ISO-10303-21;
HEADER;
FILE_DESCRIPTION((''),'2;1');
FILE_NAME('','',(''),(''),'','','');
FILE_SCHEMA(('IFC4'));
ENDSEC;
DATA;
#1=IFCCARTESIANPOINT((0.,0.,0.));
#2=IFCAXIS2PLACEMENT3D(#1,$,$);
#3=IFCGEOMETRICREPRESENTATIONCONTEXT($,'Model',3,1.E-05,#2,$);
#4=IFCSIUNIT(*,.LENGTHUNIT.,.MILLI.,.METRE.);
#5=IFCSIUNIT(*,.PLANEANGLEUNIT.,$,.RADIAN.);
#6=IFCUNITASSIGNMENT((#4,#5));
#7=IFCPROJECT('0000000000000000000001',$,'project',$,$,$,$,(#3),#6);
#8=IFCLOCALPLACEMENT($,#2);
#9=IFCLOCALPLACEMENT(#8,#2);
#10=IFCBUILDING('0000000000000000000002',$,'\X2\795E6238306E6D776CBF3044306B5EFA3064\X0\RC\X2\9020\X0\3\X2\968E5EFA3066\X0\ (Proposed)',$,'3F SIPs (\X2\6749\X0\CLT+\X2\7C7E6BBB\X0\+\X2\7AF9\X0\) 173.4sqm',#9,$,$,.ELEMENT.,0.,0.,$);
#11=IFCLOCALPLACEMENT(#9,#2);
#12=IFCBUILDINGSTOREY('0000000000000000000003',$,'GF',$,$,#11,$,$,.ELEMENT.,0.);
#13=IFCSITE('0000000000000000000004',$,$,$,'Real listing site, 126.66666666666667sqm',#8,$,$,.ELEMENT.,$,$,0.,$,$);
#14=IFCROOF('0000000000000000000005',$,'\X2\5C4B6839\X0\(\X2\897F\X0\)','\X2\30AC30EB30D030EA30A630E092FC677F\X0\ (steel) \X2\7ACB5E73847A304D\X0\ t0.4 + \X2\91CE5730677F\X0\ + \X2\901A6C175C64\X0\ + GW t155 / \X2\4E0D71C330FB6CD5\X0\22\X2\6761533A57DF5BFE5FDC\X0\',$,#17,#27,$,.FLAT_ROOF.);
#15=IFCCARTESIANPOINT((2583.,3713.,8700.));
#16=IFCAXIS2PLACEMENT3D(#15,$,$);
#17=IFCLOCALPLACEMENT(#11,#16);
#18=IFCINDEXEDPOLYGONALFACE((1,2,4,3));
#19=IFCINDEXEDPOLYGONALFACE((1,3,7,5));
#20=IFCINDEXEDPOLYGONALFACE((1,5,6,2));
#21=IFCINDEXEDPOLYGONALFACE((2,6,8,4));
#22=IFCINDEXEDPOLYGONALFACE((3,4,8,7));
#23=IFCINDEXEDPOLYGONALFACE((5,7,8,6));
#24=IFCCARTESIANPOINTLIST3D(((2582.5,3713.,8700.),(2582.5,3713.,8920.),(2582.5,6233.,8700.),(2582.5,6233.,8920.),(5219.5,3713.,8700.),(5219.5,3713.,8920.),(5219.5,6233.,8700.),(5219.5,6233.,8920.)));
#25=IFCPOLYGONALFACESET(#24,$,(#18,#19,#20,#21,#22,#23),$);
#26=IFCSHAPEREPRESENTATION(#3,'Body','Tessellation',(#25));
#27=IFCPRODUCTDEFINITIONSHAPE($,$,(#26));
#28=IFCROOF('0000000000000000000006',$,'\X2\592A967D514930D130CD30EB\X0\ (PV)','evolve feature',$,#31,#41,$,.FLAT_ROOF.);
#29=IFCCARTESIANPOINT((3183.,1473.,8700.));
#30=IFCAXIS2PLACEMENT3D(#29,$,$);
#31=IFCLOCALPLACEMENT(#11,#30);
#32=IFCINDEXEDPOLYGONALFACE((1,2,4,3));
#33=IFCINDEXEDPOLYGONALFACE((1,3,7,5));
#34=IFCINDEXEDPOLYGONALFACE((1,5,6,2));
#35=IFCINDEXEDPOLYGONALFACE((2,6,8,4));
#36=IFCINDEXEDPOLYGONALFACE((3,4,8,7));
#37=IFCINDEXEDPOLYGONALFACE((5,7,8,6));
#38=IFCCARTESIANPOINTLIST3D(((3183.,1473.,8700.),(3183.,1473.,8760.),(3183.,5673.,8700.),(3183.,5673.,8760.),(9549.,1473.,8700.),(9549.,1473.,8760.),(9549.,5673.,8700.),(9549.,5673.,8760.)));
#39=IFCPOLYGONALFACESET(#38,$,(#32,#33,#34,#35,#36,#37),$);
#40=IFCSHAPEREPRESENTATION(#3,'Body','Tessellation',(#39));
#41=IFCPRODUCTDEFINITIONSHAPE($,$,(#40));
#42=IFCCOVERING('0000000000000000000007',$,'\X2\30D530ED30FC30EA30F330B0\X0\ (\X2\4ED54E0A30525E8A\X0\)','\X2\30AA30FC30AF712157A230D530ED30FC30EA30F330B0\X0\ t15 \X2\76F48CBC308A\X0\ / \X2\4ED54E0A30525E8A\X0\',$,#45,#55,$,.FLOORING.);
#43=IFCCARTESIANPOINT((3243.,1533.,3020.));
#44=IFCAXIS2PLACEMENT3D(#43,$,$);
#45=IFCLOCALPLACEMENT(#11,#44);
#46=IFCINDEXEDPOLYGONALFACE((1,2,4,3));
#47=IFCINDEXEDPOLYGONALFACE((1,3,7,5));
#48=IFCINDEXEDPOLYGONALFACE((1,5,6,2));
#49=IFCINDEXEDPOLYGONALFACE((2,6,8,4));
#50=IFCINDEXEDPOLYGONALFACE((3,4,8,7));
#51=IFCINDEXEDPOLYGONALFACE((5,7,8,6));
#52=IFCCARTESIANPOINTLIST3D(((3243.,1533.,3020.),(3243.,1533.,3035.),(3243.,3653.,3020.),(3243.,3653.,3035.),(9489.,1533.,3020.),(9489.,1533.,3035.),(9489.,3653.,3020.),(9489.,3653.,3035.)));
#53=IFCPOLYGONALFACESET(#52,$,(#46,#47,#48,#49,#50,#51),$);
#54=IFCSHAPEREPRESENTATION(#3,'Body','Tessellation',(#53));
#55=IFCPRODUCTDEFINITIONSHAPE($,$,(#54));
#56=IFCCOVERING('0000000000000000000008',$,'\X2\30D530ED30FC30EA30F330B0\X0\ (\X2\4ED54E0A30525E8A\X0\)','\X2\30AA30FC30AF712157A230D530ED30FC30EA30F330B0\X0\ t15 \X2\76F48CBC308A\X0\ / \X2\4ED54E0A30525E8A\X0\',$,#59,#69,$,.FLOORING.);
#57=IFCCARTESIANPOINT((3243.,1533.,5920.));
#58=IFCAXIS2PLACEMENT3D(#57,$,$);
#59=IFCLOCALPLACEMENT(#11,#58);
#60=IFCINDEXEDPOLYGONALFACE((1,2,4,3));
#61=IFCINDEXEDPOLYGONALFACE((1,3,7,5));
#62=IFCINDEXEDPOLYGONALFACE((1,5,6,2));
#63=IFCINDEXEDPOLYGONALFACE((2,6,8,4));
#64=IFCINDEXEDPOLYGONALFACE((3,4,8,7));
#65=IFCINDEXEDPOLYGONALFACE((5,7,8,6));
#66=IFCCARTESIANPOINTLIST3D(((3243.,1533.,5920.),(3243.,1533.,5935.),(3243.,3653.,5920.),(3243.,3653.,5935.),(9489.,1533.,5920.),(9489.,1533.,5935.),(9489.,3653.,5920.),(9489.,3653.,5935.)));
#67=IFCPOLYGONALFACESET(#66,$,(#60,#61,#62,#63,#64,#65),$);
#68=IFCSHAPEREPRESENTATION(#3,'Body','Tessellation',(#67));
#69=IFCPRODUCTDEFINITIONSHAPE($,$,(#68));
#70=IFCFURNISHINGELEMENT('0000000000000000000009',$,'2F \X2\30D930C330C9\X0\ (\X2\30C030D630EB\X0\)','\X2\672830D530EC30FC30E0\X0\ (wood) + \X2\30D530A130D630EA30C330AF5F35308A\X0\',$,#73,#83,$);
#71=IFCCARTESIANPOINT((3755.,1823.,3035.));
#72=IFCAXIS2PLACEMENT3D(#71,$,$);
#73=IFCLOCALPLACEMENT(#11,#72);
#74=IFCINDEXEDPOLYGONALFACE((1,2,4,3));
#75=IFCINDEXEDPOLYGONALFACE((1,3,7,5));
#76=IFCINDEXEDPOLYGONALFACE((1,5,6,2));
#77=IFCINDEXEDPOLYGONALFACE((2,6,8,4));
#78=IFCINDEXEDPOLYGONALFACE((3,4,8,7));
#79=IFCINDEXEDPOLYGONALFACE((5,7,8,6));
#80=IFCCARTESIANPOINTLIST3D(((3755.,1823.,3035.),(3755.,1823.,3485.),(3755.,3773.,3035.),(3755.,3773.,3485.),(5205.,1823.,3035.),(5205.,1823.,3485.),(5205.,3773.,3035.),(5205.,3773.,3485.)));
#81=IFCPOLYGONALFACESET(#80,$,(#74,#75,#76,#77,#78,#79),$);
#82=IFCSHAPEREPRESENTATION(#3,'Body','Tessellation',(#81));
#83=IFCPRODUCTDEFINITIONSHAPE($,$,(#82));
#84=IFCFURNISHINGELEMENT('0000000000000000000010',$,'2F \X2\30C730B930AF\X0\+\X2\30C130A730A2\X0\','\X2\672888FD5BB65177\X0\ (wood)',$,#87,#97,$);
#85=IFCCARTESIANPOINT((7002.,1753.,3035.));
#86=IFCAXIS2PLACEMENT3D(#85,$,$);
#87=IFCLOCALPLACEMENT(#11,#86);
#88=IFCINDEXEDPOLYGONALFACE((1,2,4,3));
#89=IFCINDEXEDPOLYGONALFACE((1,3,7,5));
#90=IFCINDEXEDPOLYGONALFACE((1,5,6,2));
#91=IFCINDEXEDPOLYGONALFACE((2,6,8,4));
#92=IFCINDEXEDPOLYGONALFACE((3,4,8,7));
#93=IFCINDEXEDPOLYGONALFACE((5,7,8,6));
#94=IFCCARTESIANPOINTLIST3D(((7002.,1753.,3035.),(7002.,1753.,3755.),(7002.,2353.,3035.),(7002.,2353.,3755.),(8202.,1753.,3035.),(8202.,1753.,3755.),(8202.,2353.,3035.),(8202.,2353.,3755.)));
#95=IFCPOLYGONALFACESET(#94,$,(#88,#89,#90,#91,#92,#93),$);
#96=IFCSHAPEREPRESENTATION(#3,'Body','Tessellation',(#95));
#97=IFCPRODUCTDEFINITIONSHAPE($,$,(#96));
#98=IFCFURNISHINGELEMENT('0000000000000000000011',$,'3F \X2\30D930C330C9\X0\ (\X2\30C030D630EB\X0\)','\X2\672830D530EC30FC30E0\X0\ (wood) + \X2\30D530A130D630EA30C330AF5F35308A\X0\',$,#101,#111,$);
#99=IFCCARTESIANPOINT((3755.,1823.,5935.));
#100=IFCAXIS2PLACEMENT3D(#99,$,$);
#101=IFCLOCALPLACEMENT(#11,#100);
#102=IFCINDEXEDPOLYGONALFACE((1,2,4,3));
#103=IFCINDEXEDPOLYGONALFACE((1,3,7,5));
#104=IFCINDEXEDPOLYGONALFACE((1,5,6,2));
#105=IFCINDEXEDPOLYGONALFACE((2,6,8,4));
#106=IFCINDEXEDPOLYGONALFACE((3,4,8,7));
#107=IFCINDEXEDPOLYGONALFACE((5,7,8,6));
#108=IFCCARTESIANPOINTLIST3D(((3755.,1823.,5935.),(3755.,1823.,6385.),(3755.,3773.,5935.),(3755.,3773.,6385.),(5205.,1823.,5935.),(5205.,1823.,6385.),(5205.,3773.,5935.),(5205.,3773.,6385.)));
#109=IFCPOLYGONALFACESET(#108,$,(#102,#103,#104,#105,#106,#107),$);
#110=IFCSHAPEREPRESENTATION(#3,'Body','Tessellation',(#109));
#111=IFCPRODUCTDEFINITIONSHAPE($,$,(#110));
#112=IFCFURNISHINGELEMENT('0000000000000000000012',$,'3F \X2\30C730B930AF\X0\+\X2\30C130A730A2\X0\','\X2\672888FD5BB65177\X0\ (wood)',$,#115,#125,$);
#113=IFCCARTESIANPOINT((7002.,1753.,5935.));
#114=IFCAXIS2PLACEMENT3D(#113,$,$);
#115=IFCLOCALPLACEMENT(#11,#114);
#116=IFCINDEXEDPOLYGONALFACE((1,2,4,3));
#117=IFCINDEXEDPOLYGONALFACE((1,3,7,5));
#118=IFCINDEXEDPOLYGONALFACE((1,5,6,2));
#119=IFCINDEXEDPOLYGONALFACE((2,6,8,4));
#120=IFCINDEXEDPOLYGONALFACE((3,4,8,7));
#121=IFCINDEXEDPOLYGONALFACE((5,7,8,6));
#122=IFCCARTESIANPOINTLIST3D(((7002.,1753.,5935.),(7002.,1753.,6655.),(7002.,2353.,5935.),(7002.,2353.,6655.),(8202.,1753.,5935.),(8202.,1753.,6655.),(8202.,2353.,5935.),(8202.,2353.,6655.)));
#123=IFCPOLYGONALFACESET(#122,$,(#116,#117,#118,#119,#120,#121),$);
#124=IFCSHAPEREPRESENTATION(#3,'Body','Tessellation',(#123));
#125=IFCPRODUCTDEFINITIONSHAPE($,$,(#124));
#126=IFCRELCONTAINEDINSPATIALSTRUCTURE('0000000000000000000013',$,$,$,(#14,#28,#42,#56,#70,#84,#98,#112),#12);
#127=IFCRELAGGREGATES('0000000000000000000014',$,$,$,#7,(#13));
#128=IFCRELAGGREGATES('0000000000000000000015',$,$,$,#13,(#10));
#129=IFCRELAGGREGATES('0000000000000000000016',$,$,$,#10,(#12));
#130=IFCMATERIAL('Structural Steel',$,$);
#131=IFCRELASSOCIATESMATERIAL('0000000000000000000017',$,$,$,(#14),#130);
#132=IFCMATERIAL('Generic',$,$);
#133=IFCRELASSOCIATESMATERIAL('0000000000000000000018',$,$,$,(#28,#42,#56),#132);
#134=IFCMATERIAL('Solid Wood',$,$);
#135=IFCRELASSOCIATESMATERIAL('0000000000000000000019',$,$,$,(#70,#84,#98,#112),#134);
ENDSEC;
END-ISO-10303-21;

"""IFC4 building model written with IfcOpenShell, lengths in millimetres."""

from ifc_helpers import new_model, si_unit, frame, frame_2d, origin, place, context, project, spatial, rectangle, extrude, material, element, save


model = new_model("IFC4")

# Units and contexts
model_context = context("Model", 3, precision=1e-05, world=origin())
ifc_project = project(units=[si_unit("LENGTHUNIT", "METRE", prefix="MILLI"), si_unit("PLANEANGLEUNIT", "RADIAN")], contexts=[model_context])

# Site, building, storey
site_placement = place(None, origin())
site = spatial("IfcSite", under=ifc_project, at=site_placement, ObjectType="Real listing site, 126.66666666666667sqm", CompositionType="ELEMENT", RefElevation=0.0)
building_placement = place(site_placement, origin())
building = spatial("IfcBuilding", under=site, at=building_placement, Name="神戸の海沿いに建つRC造3階建て (Proposed)", ObjectType="3F SIPs (杉CLT+籾殻+竹) 173.4sqm", CompositionType="ELEMENT", ElevationOfRefHeight=0.0, ElevationOfTerrain=0.0)
storey_placement = place(building_placement, origin())
storey = spatial("IfcBuildingStorey", under=building, at=storey_placement, Name="GF", CompositionType="ELEMENT", Elevation=0.0)

# Shared definitions
ifc_material_1 = material(Name="Solid Wood")

# Roofs
ifc_material_2 = material(Name="Structural Steel")
roof_1_placement = place(storey_placement, frame((2583.0, 3713.0, 8700.0)))
element("IfcRoof", 1, at=roof_1_placement, inside=storey, material=ifc_material_2, Name="屋根(西)", Description="ガルバリウム鋼板 (steel) 立平葺き t0.4 + 野地板 + 通気層 + GW t155 / 不燃・法22条区域対応", PredefinedType="FLAT_ROOF", context=model_context, shape_type="SweptSolid", body=[
    extrude(rectangle(XDim=2637.0, YDim=2520.0, at=frame_2d((1318.0, 1260.0))), frame((2583.0, 3713.0, 8700.0)), (0.0, 0.0, 1.0), 220.0),
])
ifc_material_3 = material(Name="Generic")
roof_2_placement = place(storey_placement, frame((3183.0, 1473.0, 8700.0)))
element("IfcRoof", 2, at=roof_2_placement, inside=storey, material=ifc_material_3, Name="太陽光パネル (PV)", Description="evolve feature", PredefinedType="FLAT_ROOF", context=model_context, shape_type="SweptSolid", body=[
    extrude(rectangle(XDim=6366.0, YDim=4200.0, at=frame_2d((3183.0, 2100.0))), frame((3183.0, 1473.0, 8700.0)), (0.0, 0.0, 1.0), 60.0),
])

# Coverings
covering_1_placement = place(storey_placement, frame((3243.0, 1533.0, 3020.0)))
element("IfcCovering", 3, at=covering_1_placement, inside=storey, material=ifc_material_3, Name="フローリング (仕上げ床)", Description="オーク無垢フローリング t15 直貼り / 仕上げ床", PredefinedType="FLOORING", context=model_context, shape_type="SweptSolid", body=[
    extrude(rectangle(XDim=6246.0, YDim=2120.0, at=frame_2d((3123.0, 1060.0))), frame((3243.0, 1533.0, 3020.0)), (0.0, 0.0, 1.0), 15.0),
])
covering_2_placement = place(storey_placement, frame((3243.0, 1533.0, 5920.0)))
element("IfcCovering", 4, at=covering_2_placement, inside=storey, material=ifc_material_3, Name="フローリング (仕上げ床)", Description="オーク無垢フローリング t15 直貼り / 仕上げ床", PredefinedType="FLOORING", context=model_context, shape_type="SweptSolid", body=[
    extrude(rectangle(XDim=6246.0, YDim=2120.0, at=frame_2d((3123.0, 1060.0))), frame((3243.0, 1533.0, 5920.0)), (0.0, 0.0, 1.0), 15.0),
])

# Furnishing elements
furnishing_1_placement = place(storey_placement, frame((3755.0, 1823.0, 3035.0)))
element("IfcFurnishingElement", 5, at=furnishing_1_placement, inside=storey, material=ifc_material_1, Name="2F ベッド (ダブル)", Description="木フレーム (wood) + ファブリック張り", context=model_context, shape_type="SweptSolid", body=[
    extrude(rectangle(XDim=1450.0, YDim=1950.0, at=frame_2d((725.0, 975.0))), frame((3755.0, 1823.0, 3035.0)), (0.0, 0.0, 1.0), 450.0),
])
furnishing_2_placement = place(storey_placement, frame((7002.0, 1753.0, 3035.0)))
element("IfcFurnishingElement", 6, at=furnishing_2_placement, inside=storey, material=ifc_material_1, Name="2F デスク+チェア", Description="木製家具 (wood)", context=model_context, shape_type="SweptSolid", body=[
    extrude(rectangle(XDim=1200.0, YDim=600.0, at=frame_2d((600.0, 300.0))), frame((7002.0, 1753.0, 3035.0)), (0.0, 0.0, 1.0), 720.0),
])
furnishing_3_placement = place(storey_placement, frame((3755.0, 1823.0, 5935.0)))
element("IfcFurnishingElement", 7, at=furnishing_3_placement, inside=storey, material=ifc_material_1, Name="3F ベッド (ダブル)", Description="木フレーム (wood) + ファブリック張り", context=model_context, shape_type="SweptSolid", body=[
    extrude(rectangle(XDim=1450.0, YDim=1950.0, at=frame_2d((725.0, 975.0))), frame((3755.0, 1823.0, 5935.0)), (0.0, 0.0, 1.0), 450.0),
])
furnishing_4_placement = place(storey_placement, frame((7002.0, 1753.0, 5935.0)))
element("IfcFurnishingElement", 8, at=furnishing_4_placement, inside=storey, material=ifc_material_1, Name="3F デスク+チェア", Description="木製家具 (wood)", context=model_context, shape_type="SweptSolid", body=[
    extrude(rectangle(XDim=1200.0, YDim=600.0, at=frame_2d((600.0, 300.0))), frame((7002.0, 1753.0, 5935.0)), (0.0, 0.0, 1.0), 720.0),
])

save(model, "model.ifc")
